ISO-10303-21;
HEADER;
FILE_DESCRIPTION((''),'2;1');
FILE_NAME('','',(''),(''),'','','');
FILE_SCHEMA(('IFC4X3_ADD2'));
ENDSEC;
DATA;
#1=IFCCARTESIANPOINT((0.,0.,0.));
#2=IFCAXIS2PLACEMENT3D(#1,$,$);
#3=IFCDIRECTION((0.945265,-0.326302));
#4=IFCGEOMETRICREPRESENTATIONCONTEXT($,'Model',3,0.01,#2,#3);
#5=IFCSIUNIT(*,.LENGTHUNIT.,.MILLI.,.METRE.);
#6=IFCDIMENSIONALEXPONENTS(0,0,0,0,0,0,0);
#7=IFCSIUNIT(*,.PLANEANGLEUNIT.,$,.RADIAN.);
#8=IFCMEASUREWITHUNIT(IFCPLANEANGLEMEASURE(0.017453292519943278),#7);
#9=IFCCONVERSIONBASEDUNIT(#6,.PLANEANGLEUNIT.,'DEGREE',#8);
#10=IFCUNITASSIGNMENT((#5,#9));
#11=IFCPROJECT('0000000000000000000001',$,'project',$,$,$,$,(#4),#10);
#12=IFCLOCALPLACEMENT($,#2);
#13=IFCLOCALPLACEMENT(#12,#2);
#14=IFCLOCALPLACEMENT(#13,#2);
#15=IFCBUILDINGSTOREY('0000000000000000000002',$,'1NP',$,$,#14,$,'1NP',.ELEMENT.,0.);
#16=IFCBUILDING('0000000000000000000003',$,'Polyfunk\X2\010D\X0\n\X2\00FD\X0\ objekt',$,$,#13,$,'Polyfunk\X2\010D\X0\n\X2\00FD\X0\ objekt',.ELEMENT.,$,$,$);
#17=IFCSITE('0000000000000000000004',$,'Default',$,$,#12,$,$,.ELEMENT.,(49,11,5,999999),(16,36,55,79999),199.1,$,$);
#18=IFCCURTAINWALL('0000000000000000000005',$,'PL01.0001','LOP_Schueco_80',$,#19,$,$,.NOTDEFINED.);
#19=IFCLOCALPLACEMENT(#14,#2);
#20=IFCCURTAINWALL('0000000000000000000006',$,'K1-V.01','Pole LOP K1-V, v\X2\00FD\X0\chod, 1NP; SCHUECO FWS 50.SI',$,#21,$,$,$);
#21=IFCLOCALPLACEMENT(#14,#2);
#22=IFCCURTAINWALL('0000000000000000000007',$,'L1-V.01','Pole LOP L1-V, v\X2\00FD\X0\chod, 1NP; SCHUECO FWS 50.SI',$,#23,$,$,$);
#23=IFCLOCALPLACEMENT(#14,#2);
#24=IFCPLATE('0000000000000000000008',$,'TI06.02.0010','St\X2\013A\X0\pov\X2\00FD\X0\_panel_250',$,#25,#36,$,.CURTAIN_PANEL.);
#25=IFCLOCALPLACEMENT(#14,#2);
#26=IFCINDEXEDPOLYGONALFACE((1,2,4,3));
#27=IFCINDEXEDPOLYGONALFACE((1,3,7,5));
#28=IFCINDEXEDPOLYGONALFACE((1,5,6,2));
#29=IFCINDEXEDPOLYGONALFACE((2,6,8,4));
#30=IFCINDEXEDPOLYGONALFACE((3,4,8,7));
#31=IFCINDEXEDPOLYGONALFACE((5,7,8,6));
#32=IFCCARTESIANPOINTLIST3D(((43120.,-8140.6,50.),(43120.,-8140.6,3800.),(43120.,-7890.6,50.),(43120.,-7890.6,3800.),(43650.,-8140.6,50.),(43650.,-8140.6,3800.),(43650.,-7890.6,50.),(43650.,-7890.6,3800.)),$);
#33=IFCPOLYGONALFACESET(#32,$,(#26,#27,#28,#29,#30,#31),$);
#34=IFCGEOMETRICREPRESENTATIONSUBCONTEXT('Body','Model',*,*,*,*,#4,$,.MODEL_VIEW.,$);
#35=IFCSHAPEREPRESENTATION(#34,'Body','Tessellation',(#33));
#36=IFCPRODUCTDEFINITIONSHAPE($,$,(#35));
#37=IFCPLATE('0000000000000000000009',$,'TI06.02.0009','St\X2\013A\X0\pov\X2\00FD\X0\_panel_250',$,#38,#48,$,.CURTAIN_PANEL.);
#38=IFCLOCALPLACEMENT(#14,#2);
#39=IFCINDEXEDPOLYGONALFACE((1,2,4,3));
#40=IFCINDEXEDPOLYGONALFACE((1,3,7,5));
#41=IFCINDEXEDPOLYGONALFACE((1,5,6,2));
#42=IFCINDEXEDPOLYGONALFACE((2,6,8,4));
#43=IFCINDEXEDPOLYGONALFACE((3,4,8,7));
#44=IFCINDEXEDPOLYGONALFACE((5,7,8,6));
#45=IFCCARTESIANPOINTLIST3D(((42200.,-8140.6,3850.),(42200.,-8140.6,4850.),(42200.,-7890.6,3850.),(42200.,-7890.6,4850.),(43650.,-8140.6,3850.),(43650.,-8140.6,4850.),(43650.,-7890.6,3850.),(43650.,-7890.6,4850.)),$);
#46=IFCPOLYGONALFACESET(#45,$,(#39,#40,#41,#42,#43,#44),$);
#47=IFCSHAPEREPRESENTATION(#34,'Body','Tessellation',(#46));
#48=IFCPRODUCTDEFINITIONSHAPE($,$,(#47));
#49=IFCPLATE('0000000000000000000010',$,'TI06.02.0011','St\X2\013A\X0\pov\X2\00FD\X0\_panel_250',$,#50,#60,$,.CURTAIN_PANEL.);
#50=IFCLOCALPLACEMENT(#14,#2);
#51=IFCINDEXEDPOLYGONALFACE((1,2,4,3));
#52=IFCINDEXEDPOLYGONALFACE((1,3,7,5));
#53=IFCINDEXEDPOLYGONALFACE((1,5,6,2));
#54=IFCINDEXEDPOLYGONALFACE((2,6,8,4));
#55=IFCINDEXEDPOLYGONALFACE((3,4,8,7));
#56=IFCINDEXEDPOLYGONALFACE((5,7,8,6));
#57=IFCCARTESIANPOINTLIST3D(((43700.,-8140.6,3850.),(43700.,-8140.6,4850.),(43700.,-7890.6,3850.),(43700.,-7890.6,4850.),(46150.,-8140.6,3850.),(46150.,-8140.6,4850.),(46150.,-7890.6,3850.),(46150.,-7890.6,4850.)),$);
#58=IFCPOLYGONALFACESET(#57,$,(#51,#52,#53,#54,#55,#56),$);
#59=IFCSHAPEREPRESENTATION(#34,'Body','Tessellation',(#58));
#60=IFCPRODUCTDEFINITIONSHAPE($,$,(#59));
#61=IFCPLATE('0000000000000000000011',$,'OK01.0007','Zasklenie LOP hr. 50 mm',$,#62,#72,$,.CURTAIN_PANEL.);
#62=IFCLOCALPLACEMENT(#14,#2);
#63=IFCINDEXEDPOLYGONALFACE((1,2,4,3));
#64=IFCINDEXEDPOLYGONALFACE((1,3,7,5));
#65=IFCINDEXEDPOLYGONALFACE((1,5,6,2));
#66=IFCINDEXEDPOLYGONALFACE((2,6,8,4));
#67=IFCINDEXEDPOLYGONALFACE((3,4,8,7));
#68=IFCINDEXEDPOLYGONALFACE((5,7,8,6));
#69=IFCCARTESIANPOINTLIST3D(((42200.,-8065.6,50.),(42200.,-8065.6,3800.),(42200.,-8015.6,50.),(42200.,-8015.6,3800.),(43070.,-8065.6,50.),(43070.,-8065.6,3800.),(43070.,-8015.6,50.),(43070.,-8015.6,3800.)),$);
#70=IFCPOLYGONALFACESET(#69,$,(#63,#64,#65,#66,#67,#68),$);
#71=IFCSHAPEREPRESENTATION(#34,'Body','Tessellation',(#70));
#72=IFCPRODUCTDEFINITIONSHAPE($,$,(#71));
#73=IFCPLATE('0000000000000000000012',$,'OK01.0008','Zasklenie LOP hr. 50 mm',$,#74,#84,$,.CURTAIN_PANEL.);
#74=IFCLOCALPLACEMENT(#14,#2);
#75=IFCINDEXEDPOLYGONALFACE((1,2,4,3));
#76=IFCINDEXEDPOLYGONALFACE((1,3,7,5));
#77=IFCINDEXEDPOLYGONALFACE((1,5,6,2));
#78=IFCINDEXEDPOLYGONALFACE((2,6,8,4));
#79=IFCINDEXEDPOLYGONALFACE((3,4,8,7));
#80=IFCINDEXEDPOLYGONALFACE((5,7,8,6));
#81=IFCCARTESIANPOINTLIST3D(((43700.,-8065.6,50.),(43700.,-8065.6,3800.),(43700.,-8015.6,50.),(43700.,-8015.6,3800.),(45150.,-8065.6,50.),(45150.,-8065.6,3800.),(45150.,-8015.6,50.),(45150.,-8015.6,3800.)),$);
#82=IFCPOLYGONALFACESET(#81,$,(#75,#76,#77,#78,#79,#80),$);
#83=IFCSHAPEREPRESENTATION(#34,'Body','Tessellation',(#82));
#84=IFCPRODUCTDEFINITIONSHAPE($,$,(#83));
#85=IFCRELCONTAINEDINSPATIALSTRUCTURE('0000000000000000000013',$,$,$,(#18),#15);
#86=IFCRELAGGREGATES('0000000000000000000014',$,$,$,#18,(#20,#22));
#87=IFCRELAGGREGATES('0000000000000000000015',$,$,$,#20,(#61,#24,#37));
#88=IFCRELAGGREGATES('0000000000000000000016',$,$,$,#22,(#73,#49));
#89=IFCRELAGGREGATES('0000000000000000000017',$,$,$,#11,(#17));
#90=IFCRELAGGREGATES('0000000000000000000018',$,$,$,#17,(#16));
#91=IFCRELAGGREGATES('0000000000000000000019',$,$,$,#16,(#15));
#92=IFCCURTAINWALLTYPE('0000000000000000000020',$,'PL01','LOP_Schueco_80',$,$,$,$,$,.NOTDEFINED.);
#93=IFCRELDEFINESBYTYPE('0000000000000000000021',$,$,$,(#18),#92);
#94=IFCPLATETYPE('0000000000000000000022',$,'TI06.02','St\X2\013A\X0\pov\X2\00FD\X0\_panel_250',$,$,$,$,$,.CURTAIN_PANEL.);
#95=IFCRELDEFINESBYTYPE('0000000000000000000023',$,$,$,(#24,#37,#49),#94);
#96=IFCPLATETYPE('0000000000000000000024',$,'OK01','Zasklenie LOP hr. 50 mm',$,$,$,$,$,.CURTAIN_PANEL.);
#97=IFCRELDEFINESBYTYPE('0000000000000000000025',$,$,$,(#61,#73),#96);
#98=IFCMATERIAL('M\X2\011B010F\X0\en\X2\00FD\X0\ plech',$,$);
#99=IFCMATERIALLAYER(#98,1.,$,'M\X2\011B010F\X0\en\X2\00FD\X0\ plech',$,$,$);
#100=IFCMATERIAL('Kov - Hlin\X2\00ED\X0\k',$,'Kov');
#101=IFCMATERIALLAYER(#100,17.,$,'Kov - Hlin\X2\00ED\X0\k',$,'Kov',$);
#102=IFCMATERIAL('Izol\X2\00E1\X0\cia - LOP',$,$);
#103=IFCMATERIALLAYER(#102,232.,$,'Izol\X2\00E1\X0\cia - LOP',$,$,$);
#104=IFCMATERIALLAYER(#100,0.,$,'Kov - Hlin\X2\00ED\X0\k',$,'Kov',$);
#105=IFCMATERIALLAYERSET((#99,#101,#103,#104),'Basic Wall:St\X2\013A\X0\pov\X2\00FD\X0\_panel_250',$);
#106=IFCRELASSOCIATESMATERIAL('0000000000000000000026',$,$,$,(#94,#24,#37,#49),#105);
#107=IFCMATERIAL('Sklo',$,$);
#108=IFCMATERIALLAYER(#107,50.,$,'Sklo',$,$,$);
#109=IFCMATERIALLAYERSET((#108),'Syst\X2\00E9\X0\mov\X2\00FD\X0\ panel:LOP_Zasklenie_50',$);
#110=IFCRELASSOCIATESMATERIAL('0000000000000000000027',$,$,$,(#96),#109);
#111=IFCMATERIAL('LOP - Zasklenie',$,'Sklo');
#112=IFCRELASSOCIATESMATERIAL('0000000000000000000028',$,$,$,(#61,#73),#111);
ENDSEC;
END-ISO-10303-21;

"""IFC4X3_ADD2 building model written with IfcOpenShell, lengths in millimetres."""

from ifc_helpers import new_model, entity, si_unit, converted_unit, direction, frame, frame_2d, origin, place, context, subcontext, project, spatial, rectangle, extrude, source, transform, mapped, material, layer, layer_set, layer_usage, type_object, type_shapes, element, aggregate, save


model = new_model("IFC4X3_ADD2")

# Units and contexts
model_context = context("Model", 3, precision=0.01, world=origin(), true_north=direction((0.945265, -0.326302)))
body_context = subcontext(model_context, "Body", "Model", "MODEL_VIEW")
ifc_project = project(units=[si_unit("LENGTHUNIT", "METRE", prefix="MILLI"), converted_unit("PLANEANGLEUNIT", "DEGREE", entity("IfcPlaneAngleMeasure", 0.017453292519943278), si_unit("PLANEANGLEUNIT", "RADIAN"), dimensions=[0, 0, 0, 0, 0, 0, 0])], contexts=[model_context])

# Site, building, storey
site_placement = place(None, origin())
site = spatial("IfcSite", under=ifc_project, at=site_placement, Name="Default", CompositionType="ELEMENT", RefLatitude=(49, 11, 5, 999999), RefLongitude=(16, 36, 55, 79999), RefElevation=199.1)
building_placement = place(site_placement, origin())
building = spatial("IfcBuilding", under=site, at=building_placement, Name="Polyfunkčný objekt", LongName="Polyfunkčný objekt", CompositionType="ELEMENT")
storey_placement = place(building_placement, origin())
storey = spatial("IfcBuildingStorey", under=building, at=storey_placement, Name="1NP", LongName="1NP", CompositionType="ELEMENT", Elevation=0.0)

# Curtain walls, plates
curtain_wall_type = type_object("IfcCurtainWallType", Name="PL01", Description="LOP_Schueco_80", PredefinedType="NOTDEFINED")
curtain_wall_1_placement = place(storey_placement, origin())
curtain_wall_1 = element("IfcCurtainWall", 1, at=curtain_wall_1_placement, inside=storey, type_object=curtain_wall_type, Name="PL01.0001", Description="LOP_Schueco_80", PredefinedType="NOTDEFINED")
curtain_wall_2 = element("IfcCurtainWall", 2, Name="K1-V.01", Description="Pole LOP K1-V, východ, 1NP; SCHUECO FWS 50.SI")
curtain_wall_3 = element("IfcCurtainWall", 3, Name="L1-V.01", Description="Pole LOP L1-V, východ, 1NP; SCHUECO FWS 50.SI")
aggregate(curtain_wall_1, [curtain_wall_2, curtain_wall_3])
ifc_material_1 = material(Name="Měďený plech")
ifc_layer_1 = layer(ifc_material_1, 1.0, Name="Měďený plech")
ifc_material_2 = material(Name="Kov - Hliník", Category="Kov")
ifc_layer_2 = layer(ifc_material_2, 17.0, Name="Kov - Hliník", Category="Kov")
ifc_material_3 = material(Name="Izolácia - LOP")
ifc_layer_3 = layer(ifc_material_3, 232.0, Name="Izolácia - LOP")
ifc_layer_4 = layer(ifc_material_2, 0.0, Name="Kov - Hliník", Category="Kov")
ifc_layer_set_1 = layer_set([ifc_layer_1, ifc_layer_2, ifc_layer_3, ifc_layer_4], Name="Basic Wall:Stĺpový_panel_250")
ifc_layer_usage_1 = layer_usage(ifc_layer_set_1, "AXIS2", "POSITIVE", -125.0)
plate_type_1 = type_object("IfcPlateType", Name="TI06.02", Description="Stĺpový_panel_250", PredefinedType="CURTAIN_PANEL", material=ifc_layer_set_1)
plate_1_placement = place(storey_placement, frame((43120.0, -8015.6, 50.0)))
plate_1 = element("IfcPlate", 4, at=plate_1_placement, type_object=plate_type_1, material=ifc_layer_usage_1, Name="TI06.02.0010", Description="Stĺpový_panel_250", PredefinedType="CURTAIN_PANEL", context=body_context, shape_type="SweptSolid", body=[
    extrude(rectangle(XDim=250.0, YDim=530.0, at=frame_2d((0.0, 0.0), x_axis=(1.0, 0.0))), frame((265.0, 0.0, 0.0), z_axis=(0.0, 0.0, 1.0), x_axis=(0.0, 1.0, 0.0)), (0.0, 0.0, 1.0), 3750.0),
])
ifc_layer_usage_2 = layer_usage(ifc_layer_set_1, "AXIS2", "POSITIVE", -125.0)
plate_2_placement = place(storey_placement, frame((42200.0, -8015.6, 3850.0)))
plate_2 = element("IfcPlate", 5, at=plate_2_placement, type_object=plate_type_1, material=ifc_layer_usage_2, Name="TI06.02.0009", Description="Stĺpový_panel_250", PredefinedType="CURTAIN_PANEL", context=body_context, shape_type="SweptSolid", body=[
    extrude(rectangle(XDim=250.0, YDim=1450.0, at=frame_2d((0.0, 0.0), x_axis=(1.0, 0.0))), frame((725.0, 0.0, 0.0), z_axis=(0.0, 0.0, 1.0), x_axis=(0.0, 1.0, 0.0)), (0.0, 0.0, 1.0), 1000.0),
])
ifc_layer_usage_3 = layer_usage(ifc_layer_set_1, "AXIS2", "POSITIVE", -125.0)
plate_3_placement = place(storey_placement, frame((43700.0, -8015.6, 3850.0)))
plate_3 = element("IfcPlate", 6, at=plate_3_placement, type_object=plate_type_1, material=ifc_layer_usage_3, Name="TI06.02.0011", Description="Stĺpový_panel_250", PredefinedType="CURTAIN_PANEL", context=body_context, shape_type="SweptSolid", body=[
    extrude(rectangle(XDim=250.0, YDim=2450.0, at=frame_2d((0.0, 0.0), x_axis=(1.0, 0.0))), frame((1225.0, 0.0, 0.0), z_axis=(0.0, 0.0, 1.0), x_axis=(0.0, 1.0, 0.0)), (0.0, 0.0, 1.0), 1000.0),
])
ifc_material_4 = material(Name="LOP - Zasklenie", Category="Sklo")
ifc_material_5 = material(Name="Sklo")
ifc_layer_5 = layer(ifc_material_5, 50.0, Name="Sklo")
ifc_layer_set_2 = layer_set([ifc_layer_5], Name="Systémový panel:LOP_Zasklenie_50")
plate_type_2 = type_object("IfcPlateType", Name="OK01", Description="Zasklenie LOP hr. 50 mm", PredefinedType="CURTAIN_PANEL", material=ifc_layer_set_2)
shared_shape_1 = source(origin(), body_context, "Body", "SweptSolid", [
    extrude(rectangle(XDim=3750.0, YDim=870.0, at=frame_2d((-331.2, 0.0), x_axis=(1.0, 0.0))), frame((0.0, -50.0, 2206.2), z_axis=(0.0, 1.0, 0.0), x_axis=(0.0, 0.0, 1.0)), (0.0, 0.0, 1.0), 50.0),
])
plate_4_placement = place(curtain_wall_1_placement, frame((42635.0, -8015.6, 50.0)))
plate_4 = element("IfcPlate", 7, at=plate_4_placement, type_object=plate_type_2, material=ifc_material_4, Name="OK01.0007", Description="Zasklenie LOP hr. 50 mm", PredefinedType="CURTAIN_PANEL", context=body_context, shape_type="MappedRepresentation", body=[
    mapped(shared_shape_1, transform((0.0, 0.0, 0.0), scale=1.0)),
])
aggregate(curtain_wall_2, [plate_4, plate_1, plate_2])
shared_shape_2 = source(origin(), body_context, "Body", "SweptSolid", [
    extrude(rectangle(XDim=3750.0, YDim=1450.0, at=frame_2d((-331.2, 0.0), x_axis=(1.0, 0.0))), frame((0.0, -50.0, 2206.2), z_axis=(0.0, 1.0, 0.0), x_axis=(0.0, 0.0, 1.0)), (0.0, 0.0, 1.0), 50.0),
])
type_shapes(plate_type_2, [shared_shape_1, shared_shape_2])
plate_5_placement = place(curtain_wall_1_placement, frame((44425.0, -8015.6, 50.0)))
plate_5 = element("IfcPlate", 8, at=plate_5_placement, type_object=plate_type_2, material=ifc_material_4, Name="OK01.0008", Description="Zasklenie LOP hr. 50 mm", PredefinedType="CURTAIN_PANEL", context=body_context, shape_type="MappedRepresentation", body=[
    mapped(shared_shape_2, transform((0.0, 0.0, 0.0), scale=1.0)),
])
aggregate(curtain_wall_3, [plate_5, plate_3])

save(model, "model.ifc")
